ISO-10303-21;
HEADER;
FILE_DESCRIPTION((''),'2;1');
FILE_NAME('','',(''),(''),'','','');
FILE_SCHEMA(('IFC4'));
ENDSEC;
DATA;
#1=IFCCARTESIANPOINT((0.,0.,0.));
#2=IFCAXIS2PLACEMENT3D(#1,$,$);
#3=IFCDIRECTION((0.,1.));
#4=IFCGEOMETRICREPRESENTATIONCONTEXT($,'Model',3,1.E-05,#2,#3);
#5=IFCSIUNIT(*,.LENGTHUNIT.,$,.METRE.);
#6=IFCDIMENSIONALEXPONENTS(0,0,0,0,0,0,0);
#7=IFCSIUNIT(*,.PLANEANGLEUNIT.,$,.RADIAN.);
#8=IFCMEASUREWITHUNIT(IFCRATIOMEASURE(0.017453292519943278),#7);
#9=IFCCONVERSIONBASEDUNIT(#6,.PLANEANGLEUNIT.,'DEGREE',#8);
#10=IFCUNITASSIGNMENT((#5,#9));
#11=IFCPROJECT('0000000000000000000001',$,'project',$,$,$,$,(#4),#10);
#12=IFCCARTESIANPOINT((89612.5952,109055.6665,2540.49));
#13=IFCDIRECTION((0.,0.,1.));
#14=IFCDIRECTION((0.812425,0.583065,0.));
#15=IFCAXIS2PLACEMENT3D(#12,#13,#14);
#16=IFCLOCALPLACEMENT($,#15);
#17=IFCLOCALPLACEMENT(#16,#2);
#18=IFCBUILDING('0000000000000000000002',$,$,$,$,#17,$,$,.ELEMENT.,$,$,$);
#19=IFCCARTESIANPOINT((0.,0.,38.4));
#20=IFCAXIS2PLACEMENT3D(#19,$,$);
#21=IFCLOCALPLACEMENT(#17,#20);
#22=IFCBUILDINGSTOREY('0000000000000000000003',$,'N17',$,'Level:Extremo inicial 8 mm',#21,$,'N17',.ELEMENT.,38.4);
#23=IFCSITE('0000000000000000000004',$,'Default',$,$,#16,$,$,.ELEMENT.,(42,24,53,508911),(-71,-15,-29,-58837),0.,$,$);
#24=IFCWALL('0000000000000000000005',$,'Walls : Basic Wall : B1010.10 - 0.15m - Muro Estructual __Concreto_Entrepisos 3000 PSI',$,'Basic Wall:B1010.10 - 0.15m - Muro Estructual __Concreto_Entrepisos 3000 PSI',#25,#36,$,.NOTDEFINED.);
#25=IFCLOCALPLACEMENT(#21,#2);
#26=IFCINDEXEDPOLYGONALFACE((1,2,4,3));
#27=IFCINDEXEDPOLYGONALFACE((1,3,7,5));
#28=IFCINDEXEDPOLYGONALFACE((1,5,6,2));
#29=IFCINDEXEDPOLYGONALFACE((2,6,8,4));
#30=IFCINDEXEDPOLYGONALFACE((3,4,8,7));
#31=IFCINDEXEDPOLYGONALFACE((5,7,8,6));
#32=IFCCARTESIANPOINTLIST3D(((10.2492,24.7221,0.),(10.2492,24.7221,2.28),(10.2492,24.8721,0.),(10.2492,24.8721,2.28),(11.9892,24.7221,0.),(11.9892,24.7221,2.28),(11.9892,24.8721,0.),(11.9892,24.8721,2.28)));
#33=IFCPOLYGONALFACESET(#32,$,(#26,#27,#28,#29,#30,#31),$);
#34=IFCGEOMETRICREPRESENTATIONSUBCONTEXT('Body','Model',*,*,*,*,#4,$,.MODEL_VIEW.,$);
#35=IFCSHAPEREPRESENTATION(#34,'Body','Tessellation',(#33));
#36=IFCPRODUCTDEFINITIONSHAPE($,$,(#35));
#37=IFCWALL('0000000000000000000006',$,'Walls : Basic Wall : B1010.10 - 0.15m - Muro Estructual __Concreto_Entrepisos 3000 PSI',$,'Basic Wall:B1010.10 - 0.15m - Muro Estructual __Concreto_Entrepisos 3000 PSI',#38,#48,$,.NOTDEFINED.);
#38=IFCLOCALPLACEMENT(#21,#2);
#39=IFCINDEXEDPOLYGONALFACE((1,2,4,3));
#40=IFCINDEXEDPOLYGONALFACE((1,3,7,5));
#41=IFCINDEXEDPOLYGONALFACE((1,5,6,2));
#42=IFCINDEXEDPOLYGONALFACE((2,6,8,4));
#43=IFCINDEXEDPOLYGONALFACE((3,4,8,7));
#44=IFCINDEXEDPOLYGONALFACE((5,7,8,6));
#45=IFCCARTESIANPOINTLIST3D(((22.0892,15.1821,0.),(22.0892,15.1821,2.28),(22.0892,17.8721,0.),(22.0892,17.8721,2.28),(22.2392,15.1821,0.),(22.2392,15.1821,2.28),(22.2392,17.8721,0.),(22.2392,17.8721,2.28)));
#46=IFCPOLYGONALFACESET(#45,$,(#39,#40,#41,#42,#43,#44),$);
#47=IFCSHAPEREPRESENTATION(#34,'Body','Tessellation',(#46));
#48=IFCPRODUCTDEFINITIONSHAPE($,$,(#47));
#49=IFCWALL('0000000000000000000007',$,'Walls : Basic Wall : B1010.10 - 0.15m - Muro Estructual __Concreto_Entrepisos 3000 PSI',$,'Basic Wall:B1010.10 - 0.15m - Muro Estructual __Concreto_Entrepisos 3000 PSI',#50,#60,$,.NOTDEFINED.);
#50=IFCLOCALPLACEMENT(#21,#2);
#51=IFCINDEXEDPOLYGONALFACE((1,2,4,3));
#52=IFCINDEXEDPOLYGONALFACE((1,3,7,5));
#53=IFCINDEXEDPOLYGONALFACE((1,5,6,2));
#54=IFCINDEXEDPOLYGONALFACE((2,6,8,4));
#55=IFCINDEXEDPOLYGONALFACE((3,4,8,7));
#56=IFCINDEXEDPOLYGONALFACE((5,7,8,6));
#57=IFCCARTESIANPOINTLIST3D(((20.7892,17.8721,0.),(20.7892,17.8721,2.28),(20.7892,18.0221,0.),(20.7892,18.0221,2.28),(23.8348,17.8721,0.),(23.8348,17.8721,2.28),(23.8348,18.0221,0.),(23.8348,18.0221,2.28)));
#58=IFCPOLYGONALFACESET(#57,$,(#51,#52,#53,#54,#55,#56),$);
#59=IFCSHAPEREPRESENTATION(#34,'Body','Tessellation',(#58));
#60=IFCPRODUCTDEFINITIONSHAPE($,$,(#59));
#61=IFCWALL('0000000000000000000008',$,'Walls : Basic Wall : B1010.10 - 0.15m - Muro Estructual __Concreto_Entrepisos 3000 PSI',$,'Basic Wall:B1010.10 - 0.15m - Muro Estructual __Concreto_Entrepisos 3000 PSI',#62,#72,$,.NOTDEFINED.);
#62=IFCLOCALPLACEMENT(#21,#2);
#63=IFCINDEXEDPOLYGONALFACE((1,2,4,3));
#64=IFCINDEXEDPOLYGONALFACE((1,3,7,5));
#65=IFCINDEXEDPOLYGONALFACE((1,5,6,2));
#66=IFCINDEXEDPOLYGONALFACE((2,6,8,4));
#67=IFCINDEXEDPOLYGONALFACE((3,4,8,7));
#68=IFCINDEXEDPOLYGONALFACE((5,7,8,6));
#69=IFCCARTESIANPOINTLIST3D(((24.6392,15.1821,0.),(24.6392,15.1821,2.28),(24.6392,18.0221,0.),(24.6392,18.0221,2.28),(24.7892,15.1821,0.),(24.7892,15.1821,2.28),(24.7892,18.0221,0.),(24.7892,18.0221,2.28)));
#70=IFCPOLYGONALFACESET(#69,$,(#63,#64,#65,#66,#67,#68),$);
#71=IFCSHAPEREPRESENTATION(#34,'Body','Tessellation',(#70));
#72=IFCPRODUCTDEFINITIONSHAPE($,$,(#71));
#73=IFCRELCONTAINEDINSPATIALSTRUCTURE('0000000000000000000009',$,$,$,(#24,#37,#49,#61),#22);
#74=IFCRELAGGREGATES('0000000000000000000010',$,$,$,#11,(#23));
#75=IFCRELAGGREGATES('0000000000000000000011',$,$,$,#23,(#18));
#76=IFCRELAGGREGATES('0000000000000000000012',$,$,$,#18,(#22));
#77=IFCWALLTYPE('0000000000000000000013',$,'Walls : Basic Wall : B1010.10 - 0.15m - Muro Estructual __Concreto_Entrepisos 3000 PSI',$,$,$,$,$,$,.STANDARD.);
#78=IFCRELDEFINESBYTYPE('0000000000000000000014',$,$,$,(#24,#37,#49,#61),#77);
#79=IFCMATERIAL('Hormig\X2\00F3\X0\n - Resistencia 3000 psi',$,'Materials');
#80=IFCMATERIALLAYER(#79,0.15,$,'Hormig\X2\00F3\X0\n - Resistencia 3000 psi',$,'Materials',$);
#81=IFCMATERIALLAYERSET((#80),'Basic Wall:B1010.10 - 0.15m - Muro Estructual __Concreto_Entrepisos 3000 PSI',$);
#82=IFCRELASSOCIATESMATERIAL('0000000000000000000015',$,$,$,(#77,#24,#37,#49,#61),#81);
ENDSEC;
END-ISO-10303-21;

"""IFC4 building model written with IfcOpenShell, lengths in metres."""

from ifc_helpers import new_model, entity, si_unit, converted_unit, direction, frame, frame_2d, origin, place, context, subcontext, project, spatial, rectangle, extrude, material, layer, layer_set, layer_usage, type_object, element, save


model = new_model("IFC4")

# Units and contexts
model_context = context("Model", 3, precision=1e-05, world=origin(), true_north=direction((0.0, 1.0)))
body_context = subcontext(model_context, "Body", "Model", "MODEL_VIEW")
ifc_project = project(units=[si_unit("LENGTHUNIT", "METRE"), converted_unit("PLANEANGLEUNIT", "DEGREE", entity("IfcRatioMeasure", 0.017453292519943278), si_unit("PLANEANGLEUNIT", "RADIAN"), dimensions=[0, 0, 0, 0, 0, 0, 0])], contexts=[model_context])

# Site, building, storey
site_placement = place(None, frame((89612.5952, 109055.6665, 2540.49), z_axis=(0.0, 0.0, 1.0), x_axis=(0.812425, 0.583065, 0.0)))
site = spatial("IfcSite", under=ifc_project, at=site_placement, Name="Default", CompositionType="ELEMENT", RefLatitude=(42, 24, 53, 508911), RefLongitude=(-71, -15, -29, -58837), RefElevation=0.0)
building_placement = place(site_placement, origin())
building = spatial("IfcBuilding", under=site, at=building_placement, CompositionType="ELEMENT")
storey_placement = place(building_placement, frame((0.0, 0.0, 38.4)))
storey = spatial("IfcBuildingStorey", under=building, at=storey_placement, Name="N17", ObjectType="Level:Extremo inicial 8 mm", LongName="N17", CompositionType="ELEMENT", Elevation=38.4)

# Walls
ifc_material = material(Name="Hormigón - Resistencia 3000 psi", Category="Materials")
ifc_layer_1 = layer(ifc_material, 0.15, Name="Hormigón - Resistencia 3000 psi", Category="Materials")
ifc_layer_set_1 = layer_set([ifc_layer_1], Name="Basic Wall:B1010.10 - 0.15m - Muro Estructual __Concreto_Entrepisos 3000 PSI")
wall_type_1 = type_object("IfcWallType", Name="Walls : Basic Wall : B1010.10 - 0.15m - Muro Estructual __Concreto_Entrepisos 3000 PSI", PredefinedType="STANDARD", material=ifc_layer_set_1)
ifc_layer_usage_1 = layer_usage(ifc_layer_set_1, "AXIS2", "POSITIVE", -0.075)
wall_1_placement = place(storey_placement, frame((11.9892, 24.7971, 0.0), z_axis=(0.0, 0.0, 1.0), x_axis=(-1.0, 0.0, 0.0)))
element("IfcWall", 1, at=wall_1_placement, inside=storey, type_object=wall_type_1, material=ifc_layer_usage_1, Name="Walls : Basic Wall : B1010.10 - 0.15m - Muro Estructual __Concreto_Entrepisos 3000 PSI", ObjectType="Basic Wall:B1010.10 - 0.15m - Muro Estructual __Concreto_Entrepisos 3000 PSI", PredefinedType="NOTDEFINED", context=body_context, shape_type="SweptSolid", body=[
    extrude(rectangle(XDim=1.74, YDim=0.15, at=frame_2d((0.87, 0.0), x_axis=(-1.0, 0.0))), origin(), (0.0, 0.0, 1.0), 2.28),
])
ifc_layer_usage_2 = layer_usage(ifc_layer_set_1, "AXIS2", "POSITIVE", -0.075)
wall_2_placement = place(storey_placement, frame((22.1642, 15.1821, 0.0), z_axis=(0.0, 0.0, 1.0), x_axis=(0.0, 1.0, 0.0)))
element("IfcWall", 2, at=wall_2_placement, inside=storey, type_object=wall_type_1, material=ifc_layer_usage_2, Name="Walls : Basic Wall : B1010.10 - 0.15m - Muro Estructual __Concreto_Entrepisos 3000 PSI", ObjectType="Basic Wall:B1010.10 - 0.15m - Muro Estructual __Concreto_Entrepisos 3000 PSI", PredefinedType="NOTDEFINED", context=body_context, shape_type="SweptSolid", body=[
    extrude(rectangle(XDim=2.69, YDim=0.15, at=frame_2d((1.345, 0.0), x_axis=(-1.0, 0.0))), origin(), (0.0, 0.0, 1.0), 2.28),
])
ifc_layer_usage_3 = layer_usage(ifc_layer_set_1, "AXIS2", "POSITIVE", -0.075)
wall_3_placement = place(storey_placement, frame((20.7892, 17.9471, 0.0)))
element("IfcWall", 3, at=wall_3_placement, inside=storey, type_object=wall_type_1, material=ifc_layer_usage_3, Name="Walls : Basic Wall : B1010.10 - 0.15m - Muro Estructual __Concreto_Entrepisos 3000 PSI", ObjectType="Basic Wall:B1010.10 - 0.15m - Muro Estructual __Concreto_Entrepisos 3000 PSI", PredefinedType="NOTDEFINED", context=body_context, shape_type="SweptSolid", body=[
    extrude(rectangle(XDim=3.0455, YDim=0.15, at=frame_2d((1.5228, 0.0), x_axis=(-1.0, 0.0))), origin(), (0.0, 0.0, 1.0), 2.28),
])
ifc_layer_usage_4 = layer_usage(ifc_layer_set_1, "AXIS2", "POSITIVE", -0.075)
wall_4_placement = place(storey_placement, frame((24.7142, 15.1821, 0.0), z_axis=(0.0, 0.0, 1.0), x_axis=(0.0, 1.0, 0.0)))
element("IfcWall", 4, at=wall_4_placement, inside=storey, type_object=wall_type_1, material=ifc_layer_usage_4, Name="Walls : Basic Wall : B1010.10 - 0.15m - Muro Estructual __Concreto_Entrepisos 3000 PSI", ObjectType="Basic Wall:B1010.10 - 0.15m - Muro Estructual __Concreto_Entrepisos 3000 PSI", PredefinedType="NOTDEFINED", context=body_context, shape_type="SweptSolid", body=[
    extrude(rectangle(XDim=2.84, YDim=0.15, at=frame_2d((1.42, 0.0), x_axis=(-1.0, 0.0))), origin(), (0.0, 0.0, 1.0), 2.28),
])

save(model, "model.ifc")
